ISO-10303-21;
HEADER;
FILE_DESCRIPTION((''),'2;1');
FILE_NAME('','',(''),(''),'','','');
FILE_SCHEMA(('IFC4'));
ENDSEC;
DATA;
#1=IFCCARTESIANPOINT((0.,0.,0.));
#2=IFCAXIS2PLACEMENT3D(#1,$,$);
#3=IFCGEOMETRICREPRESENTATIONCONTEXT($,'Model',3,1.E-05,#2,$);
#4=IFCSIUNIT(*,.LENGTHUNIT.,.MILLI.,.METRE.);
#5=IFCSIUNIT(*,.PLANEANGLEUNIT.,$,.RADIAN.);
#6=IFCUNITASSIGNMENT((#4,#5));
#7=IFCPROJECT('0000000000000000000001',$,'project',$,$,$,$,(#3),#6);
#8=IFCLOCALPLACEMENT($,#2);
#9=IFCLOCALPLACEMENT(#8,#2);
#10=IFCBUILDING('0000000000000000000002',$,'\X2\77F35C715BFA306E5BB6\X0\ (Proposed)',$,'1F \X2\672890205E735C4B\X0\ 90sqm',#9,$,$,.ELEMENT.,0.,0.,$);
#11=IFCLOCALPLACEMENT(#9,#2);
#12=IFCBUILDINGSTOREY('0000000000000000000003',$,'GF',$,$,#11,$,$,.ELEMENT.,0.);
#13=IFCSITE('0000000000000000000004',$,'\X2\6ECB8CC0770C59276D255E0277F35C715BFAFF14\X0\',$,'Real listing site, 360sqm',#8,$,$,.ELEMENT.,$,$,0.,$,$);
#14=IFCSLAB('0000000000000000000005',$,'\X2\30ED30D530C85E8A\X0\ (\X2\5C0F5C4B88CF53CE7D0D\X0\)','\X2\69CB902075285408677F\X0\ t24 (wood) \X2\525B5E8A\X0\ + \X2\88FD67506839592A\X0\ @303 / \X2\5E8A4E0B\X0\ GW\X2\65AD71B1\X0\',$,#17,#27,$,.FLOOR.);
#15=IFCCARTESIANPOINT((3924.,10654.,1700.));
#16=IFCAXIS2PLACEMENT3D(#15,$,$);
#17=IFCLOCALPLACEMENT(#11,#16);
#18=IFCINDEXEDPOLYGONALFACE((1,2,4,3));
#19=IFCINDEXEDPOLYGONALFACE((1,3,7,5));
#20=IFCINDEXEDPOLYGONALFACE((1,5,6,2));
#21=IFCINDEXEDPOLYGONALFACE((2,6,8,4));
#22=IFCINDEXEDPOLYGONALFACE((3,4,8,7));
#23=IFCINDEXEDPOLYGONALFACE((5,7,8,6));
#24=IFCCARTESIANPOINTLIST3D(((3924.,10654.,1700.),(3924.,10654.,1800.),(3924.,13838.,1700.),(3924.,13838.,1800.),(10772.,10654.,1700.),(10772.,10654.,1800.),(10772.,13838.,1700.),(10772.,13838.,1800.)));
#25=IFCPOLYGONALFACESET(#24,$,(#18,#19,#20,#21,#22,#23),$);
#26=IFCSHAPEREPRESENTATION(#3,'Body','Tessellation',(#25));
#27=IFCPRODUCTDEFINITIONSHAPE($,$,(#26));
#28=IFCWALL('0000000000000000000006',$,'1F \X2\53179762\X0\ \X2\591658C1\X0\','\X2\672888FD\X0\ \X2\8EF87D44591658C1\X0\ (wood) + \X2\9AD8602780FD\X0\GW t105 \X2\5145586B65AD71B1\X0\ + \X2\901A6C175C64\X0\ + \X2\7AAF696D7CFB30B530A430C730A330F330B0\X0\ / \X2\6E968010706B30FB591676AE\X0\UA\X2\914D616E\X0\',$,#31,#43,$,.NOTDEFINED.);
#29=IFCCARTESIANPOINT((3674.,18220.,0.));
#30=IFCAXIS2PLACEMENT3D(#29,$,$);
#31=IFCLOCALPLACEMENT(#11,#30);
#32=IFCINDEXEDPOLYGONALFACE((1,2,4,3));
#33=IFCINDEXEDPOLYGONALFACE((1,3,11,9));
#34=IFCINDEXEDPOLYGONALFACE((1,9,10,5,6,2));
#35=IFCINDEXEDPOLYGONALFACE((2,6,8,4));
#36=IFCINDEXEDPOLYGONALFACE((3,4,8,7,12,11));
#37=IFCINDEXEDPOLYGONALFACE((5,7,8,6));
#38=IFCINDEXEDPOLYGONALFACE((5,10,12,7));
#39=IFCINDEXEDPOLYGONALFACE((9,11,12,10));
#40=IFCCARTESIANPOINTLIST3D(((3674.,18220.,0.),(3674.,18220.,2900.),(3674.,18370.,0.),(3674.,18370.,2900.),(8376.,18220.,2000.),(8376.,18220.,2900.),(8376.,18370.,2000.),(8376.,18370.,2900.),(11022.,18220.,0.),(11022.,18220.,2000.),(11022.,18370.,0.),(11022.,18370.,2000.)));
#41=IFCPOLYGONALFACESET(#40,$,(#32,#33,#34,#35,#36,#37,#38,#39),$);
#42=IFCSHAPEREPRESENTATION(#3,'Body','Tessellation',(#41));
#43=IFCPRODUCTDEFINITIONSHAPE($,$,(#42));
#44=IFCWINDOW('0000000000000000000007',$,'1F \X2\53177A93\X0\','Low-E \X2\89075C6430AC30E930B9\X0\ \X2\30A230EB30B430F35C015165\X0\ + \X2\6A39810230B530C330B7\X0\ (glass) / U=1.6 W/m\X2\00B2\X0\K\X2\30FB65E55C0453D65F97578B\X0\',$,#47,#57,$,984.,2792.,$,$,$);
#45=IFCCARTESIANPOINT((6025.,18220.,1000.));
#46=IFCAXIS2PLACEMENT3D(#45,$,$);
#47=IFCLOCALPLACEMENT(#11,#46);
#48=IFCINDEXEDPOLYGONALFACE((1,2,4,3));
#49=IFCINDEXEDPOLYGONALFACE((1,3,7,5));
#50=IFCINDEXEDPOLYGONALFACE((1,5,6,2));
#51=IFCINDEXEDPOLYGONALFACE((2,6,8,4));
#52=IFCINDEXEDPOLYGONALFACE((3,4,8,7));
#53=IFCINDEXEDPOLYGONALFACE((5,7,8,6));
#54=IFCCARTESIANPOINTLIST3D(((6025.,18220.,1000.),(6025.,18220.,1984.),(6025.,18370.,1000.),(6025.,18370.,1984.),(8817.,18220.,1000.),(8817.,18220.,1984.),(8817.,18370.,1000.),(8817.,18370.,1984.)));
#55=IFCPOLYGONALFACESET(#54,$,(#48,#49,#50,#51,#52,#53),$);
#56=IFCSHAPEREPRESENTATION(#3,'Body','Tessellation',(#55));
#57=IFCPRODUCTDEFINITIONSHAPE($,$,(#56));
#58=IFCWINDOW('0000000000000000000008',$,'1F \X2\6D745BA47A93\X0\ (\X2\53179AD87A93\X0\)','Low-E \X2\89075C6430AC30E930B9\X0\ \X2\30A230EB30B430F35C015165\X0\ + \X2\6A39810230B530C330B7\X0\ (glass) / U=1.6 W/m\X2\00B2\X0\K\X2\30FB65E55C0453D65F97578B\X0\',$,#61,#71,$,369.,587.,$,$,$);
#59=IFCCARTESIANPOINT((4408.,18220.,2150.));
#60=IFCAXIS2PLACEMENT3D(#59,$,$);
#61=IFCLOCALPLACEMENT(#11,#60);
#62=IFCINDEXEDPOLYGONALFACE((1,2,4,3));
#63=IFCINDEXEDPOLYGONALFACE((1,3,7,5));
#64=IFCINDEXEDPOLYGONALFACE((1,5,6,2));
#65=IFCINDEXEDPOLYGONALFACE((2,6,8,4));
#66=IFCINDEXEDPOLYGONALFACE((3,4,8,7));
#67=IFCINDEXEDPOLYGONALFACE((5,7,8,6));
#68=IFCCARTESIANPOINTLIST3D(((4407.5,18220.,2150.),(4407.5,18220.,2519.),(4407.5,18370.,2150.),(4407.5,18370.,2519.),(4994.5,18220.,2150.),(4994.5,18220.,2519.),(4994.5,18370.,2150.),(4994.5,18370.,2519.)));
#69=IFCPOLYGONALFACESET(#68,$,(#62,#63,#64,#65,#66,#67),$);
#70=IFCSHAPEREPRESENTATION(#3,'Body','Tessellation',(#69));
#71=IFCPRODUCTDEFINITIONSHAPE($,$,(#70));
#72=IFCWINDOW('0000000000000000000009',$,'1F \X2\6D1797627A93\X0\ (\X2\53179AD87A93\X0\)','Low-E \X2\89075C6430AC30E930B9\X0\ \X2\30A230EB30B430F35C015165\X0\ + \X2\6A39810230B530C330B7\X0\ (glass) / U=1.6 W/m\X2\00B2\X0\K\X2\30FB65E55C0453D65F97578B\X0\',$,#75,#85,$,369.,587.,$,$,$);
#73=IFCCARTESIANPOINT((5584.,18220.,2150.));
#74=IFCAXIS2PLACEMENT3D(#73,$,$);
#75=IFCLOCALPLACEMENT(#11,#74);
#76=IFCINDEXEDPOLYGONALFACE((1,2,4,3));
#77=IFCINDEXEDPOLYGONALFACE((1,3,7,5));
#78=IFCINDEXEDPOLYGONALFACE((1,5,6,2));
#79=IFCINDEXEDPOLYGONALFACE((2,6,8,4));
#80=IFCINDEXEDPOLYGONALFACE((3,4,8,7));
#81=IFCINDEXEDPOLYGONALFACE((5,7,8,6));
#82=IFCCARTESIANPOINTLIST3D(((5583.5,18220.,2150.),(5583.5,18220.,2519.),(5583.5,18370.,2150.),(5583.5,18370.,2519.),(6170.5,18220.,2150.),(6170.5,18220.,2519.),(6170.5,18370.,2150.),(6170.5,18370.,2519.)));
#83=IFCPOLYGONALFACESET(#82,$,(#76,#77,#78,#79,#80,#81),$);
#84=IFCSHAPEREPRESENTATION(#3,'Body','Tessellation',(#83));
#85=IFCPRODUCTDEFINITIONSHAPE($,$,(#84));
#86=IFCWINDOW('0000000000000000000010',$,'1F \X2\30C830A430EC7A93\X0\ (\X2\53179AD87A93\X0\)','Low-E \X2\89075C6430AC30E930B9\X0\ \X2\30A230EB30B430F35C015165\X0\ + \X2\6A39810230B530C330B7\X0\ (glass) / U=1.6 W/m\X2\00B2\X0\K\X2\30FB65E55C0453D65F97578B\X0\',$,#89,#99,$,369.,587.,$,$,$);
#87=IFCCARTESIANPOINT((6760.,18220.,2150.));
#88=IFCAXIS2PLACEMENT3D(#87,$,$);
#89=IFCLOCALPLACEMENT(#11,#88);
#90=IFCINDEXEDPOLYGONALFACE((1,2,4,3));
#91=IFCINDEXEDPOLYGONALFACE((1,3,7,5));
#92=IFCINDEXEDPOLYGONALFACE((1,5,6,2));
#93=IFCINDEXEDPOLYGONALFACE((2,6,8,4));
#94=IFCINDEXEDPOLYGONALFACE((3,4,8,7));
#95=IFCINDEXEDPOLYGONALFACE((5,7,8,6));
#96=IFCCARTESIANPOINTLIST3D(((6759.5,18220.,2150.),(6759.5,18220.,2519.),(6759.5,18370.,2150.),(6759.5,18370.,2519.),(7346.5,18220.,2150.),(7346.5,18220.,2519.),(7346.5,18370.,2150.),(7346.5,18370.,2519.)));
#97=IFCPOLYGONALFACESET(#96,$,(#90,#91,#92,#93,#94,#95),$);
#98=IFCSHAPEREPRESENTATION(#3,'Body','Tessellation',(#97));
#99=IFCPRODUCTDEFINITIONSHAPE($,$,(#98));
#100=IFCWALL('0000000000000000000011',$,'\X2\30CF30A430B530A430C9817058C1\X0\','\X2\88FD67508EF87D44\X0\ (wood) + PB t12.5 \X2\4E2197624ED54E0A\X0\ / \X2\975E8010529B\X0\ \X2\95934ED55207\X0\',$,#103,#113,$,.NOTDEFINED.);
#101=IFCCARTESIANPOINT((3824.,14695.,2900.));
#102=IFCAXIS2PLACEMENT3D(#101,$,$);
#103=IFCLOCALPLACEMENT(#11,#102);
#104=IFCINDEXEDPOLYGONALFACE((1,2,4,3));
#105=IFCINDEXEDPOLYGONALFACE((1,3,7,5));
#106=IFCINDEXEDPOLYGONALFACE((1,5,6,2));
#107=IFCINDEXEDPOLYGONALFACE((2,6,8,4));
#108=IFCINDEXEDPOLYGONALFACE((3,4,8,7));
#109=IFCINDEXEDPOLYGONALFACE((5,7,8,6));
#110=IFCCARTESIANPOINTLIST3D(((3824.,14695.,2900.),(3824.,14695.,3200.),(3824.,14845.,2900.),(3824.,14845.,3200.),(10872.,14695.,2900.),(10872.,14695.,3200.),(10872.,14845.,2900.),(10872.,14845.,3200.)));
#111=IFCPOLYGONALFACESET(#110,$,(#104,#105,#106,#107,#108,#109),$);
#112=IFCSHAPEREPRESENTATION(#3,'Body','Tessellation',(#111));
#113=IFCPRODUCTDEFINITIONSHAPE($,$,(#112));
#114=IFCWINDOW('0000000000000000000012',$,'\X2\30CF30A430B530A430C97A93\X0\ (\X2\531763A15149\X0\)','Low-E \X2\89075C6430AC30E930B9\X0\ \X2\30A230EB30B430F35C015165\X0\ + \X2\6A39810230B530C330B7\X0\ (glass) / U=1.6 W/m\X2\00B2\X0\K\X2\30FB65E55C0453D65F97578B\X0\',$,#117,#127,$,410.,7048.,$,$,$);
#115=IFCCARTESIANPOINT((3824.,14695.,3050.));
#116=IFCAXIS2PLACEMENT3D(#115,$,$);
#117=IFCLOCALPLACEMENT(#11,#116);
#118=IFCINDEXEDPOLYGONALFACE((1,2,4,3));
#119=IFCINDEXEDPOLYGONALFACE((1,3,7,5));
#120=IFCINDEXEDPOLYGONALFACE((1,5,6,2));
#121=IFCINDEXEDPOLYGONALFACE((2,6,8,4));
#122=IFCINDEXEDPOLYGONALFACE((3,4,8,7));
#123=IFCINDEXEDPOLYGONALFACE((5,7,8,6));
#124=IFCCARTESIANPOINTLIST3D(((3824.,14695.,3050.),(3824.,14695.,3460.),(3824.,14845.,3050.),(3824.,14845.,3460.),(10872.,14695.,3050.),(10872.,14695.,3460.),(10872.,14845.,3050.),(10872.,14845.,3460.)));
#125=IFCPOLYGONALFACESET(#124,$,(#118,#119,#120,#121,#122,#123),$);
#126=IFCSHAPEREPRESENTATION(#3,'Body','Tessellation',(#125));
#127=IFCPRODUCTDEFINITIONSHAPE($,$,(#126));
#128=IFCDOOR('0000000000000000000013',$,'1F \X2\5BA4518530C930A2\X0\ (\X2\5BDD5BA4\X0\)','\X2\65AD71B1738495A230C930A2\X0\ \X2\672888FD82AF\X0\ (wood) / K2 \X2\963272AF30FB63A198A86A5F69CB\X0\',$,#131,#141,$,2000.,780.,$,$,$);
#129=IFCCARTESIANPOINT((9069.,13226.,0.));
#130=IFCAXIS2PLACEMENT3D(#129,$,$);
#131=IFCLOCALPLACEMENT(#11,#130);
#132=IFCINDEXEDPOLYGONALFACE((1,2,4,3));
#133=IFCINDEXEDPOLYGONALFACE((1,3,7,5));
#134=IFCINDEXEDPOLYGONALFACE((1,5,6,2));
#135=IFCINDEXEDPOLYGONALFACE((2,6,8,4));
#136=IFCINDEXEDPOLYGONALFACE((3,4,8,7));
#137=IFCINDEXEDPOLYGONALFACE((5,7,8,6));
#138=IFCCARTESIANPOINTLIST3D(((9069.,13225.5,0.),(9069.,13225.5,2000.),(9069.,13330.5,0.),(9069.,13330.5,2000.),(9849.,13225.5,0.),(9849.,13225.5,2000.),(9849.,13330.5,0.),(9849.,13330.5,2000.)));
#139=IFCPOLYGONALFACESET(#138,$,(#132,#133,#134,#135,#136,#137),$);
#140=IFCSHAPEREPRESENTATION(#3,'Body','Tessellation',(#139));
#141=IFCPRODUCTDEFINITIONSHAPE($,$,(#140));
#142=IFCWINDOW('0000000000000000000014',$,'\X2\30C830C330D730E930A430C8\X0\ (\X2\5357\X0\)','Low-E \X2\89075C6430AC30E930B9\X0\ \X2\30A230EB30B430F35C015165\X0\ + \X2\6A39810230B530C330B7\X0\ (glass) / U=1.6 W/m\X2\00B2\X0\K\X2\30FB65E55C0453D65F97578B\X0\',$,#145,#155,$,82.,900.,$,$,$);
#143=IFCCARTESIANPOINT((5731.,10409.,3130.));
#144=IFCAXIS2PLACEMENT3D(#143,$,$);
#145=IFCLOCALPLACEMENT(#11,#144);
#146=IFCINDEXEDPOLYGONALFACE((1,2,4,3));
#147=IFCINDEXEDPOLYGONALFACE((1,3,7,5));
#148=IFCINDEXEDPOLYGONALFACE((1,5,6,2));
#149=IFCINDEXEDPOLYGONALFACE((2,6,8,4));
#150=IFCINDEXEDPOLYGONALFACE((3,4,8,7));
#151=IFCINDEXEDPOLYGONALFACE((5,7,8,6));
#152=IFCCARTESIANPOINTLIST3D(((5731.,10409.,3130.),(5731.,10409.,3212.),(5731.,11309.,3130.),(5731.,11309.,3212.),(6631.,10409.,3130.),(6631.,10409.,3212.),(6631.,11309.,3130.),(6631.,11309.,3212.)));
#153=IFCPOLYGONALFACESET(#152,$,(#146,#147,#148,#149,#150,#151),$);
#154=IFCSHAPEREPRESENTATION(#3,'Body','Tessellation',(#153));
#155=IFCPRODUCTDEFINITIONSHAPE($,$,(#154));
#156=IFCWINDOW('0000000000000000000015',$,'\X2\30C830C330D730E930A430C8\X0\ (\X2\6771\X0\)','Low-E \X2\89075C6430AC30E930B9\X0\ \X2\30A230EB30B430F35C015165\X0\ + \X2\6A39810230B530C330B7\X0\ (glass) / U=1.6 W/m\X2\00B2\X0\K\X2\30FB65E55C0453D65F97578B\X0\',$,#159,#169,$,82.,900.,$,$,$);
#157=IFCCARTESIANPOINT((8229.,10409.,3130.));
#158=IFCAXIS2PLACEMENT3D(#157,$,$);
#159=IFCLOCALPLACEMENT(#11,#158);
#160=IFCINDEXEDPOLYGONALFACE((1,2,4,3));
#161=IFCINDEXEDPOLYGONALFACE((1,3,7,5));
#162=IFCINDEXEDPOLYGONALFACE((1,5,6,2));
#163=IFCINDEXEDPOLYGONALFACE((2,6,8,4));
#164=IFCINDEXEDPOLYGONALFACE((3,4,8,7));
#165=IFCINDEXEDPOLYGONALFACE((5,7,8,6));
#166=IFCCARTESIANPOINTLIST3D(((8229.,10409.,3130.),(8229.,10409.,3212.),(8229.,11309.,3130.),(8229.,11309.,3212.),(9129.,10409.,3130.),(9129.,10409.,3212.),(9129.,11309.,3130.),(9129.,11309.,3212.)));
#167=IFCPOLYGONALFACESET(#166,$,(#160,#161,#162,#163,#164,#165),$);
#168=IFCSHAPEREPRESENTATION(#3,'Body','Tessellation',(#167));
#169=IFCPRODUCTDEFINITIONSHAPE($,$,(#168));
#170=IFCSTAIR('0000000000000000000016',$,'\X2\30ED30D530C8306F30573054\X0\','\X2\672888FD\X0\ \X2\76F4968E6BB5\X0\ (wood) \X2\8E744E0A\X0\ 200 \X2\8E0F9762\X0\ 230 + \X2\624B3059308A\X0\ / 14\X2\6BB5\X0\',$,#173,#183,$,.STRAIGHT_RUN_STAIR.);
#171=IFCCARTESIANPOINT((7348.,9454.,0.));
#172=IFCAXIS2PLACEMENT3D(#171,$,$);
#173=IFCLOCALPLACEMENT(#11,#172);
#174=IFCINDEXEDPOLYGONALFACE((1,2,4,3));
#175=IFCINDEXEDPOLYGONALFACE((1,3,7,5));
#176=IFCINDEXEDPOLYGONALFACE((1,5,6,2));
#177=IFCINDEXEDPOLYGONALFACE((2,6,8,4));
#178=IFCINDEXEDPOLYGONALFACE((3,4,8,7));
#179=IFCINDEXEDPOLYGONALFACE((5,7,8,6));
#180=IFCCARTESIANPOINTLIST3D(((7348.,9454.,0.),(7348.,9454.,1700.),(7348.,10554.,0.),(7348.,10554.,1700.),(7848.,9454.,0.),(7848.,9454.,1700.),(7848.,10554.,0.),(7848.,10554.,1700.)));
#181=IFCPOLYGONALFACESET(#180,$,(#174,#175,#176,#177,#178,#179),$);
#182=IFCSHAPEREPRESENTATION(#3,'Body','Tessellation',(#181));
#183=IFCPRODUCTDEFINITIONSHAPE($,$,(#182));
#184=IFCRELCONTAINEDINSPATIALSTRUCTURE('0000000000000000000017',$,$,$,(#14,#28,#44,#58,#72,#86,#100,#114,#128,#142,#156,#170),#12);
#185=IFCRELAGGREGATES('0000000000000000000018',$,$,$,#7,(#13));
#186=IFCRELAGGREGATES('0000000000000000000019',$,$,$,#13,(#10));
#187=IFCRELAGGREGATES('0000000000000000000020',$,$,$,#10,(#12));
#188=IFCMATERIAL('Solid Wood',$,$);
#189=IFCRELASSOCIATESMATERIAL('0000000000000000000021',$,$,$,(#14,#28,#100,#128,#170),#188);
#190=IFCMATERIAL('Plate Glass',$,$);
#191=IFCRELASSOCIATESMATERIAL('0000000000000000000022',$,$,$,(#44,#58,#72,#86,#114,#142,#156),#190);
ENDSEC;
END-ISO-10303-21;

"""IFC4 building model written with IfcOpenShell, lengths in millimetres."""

from ifc_helpers import new_model, si_unit, frame, frame_2d, origin, place, context, project, spatial, rectangle, extrude, material, element, fill, save


model = new_model("IFC4")

# Units and contexts
model_context = context("Model", 3, precision=1e-05, world=origin())
ifc_project = project(units=[si_unit("LENGTHUNIT", "METRE", prefix="MILLI"), si_unit("PLANEANGLEUNIT", "RADIAN")], contexts=[model_context])

# Site, building, storey
site_placement = place(None, origin())
site = spatial("IfcSite", under=ifc_project, at=site_placement, Name="滋賀県大津市石山寺４", ObjectType="Real listing site, 360sqm", CompositionType="ELEMENT", RefElevation=0.0)
building_placement = place(site_placement, origin())
building = spatial("IfcBuilding", under=site, at=building_placement, Name="石山寺の家 (Proposed)", ObjectType="1F 木造平屋 90sqm", CompositionType="ELEMENT", ElevationOfRefHeight=0.0, ElevationOfTerrain=0.0)
storey_placement = place(building_placement, origin())
storey = spatial("IfcBuildingStorey", under=building, at=storey_placement, Name="GF", CompositionType="ELEMENT", Elevation=0.0)

# Slab
ifc_material_1 = material(Name="Solid Wood")
slab_placement = place(storey_placement, frame((3924.0, 10654.0, 1700.0)))
element("IfcSlab", 1, at=slab_placement, inside=storey, material=ifc_material_1, Name="ロフト床 (小屋裏収納)", Description="構造用合板 t24 (wood) 剛床 + 製材根太 @303 / 床下 GW断熱", PredefinedType="FLOOR", context=model_context, shape_type="SweptSolid", body=[
    extrude(rectangle(XDim=6848.0, YDim=3184.0, at=frame_2d((3424.0, 1592.0))), frame((3924.0, 10654.0, 1700.0)), (0.0, 0.0, 1.0), 100.0),
])

# Wall, openings, windows
wall_1_placement = place(storey_placement, frame((3674.0, 18220.0, 0.0)))
wall_1 = element("IfcWall", 2, at=wall_1_placement, inside=storey, material=ifc_material_1, Name="1F 北面 外壁", Description="木製 軸組外壁 (wood) + 高性能GW t105 充填断熱 + 通気層 + 窯業系サイディング / 準耐火・外皮UA配慮", PredefinedType="NOTDEFINED", context=model_context, shape_type="SweptSolid", body=[
    extrude(rectangle(XDim=7348.0, YDim=150.0, at=frame_2d((3674.0, 75.0))), frame((3674.0, 18220.0, 0.0)), (0.0, 0.0, 1.0), 2900.0),
])
opening_1_placement = place(storey_placement, frame((6025.0, 18220.0, 1000.0)))
opening_1 = element("IfcOpeningElement", 3, at=opening_1_placement, cuts=wall_1, PredefinedType="NOTDEFINED", context=model_context, shape_type="SweptSolid", body=[
    extrude(rectangle(XDim=2792.0, YDim=150.0, at=frame_2d((1396.0, 75.0))), frame((6025.0, 18220.0, 1000.0)), (0.0, 0.0, 1.0), 984.0),
])
opening_2_placement = place(storey_placement, frame((4408.0, 18220.0, 2150.0)))
opening_2 = element("IfcOpeningElement", 4, at=opening_2_placement, cuts=wall_1, PredefinedType="NOTDEFINED", context=model_context, shape_type="SweptSolid", body=[
    extrude(rectangle(XDim=587.0, YDim=150.0, at=frame_2d((293.0, 75.0))), frame((4408.0, 18220.0, 2150.0)), (0.0, 0.0, 1.0), 369.0),
])
opening_3_placement = place(storey_placement, frame((5584.0, 18220.0, 2150.0)))
opening_3 = element("IfcOpeningElement", 5, at=opening_3_placement, cuts=wall_1, PredefinedType="NOTDEFINED", context=model_context, shape_type="SweptSolid", body=[
    extrude(rectangle(XDim=587.0, YDim=150.0, at=frame_2d((293.0, 75.0))), frame((5584.0, 18220.0, 2150.0)), (0.0, 0.0, 1.0), 369.0),
])
opening_4_placement = place(storey_placement, frame((6760.0, 18220.0, 2150.0)))
opening_4 = element("IfcOpeningElement", 6, at=opening_4_placement, cuts=wall_1, PredefinedType="NOTDEFINED", context=model_context, shape_type="SweptSolid", body=[
    extrude(rectangle(XDim=587.0, YDim=150.0, at=frame_2d((293.0, 75.0))), frame((6760.0, 18220.0, 2150.0)), (0.0, 0.0, 1.0), 369.0),
])
ifc_material_2 = material(Name="Plate Glass")
window_1_placement = place(storey_placement, frame((6025.0, 18220.0, 1000.0)))
window_1 = element("IfcWindow", 7, at=window_1_placement, inside=storey, material=ifc_material_2, Name="1F 北窓", Description="Low-E 複層ガラス アルゴン封入 + 樹脂サッシ (glass) / U=1.6 W/m²K・日射取得型", OverallHeight=984.0, OverallWidth=2792.0, context=model_context, shape_type="SweptSolid", body=[
    extrude(rectangle(XDim=2792.0, YDim=150.0, at=frame_2d((1396.0, 75.0))), frame((6025.0, 18220.0, 1000.0)), (0.0, 0.0, 1.0), 984.0),
])
fill(opening_1, window_1)
window_2_placement = place(storey_placement, frame((4408.0, 18220.0, 2150.0)))
window_2 = element("IfcWindow", 8, at=window_2_placement, inside=storey, material=ifc_material_2, Name="1F 浴室窓 (北高窓)", Description="Low-E 複層ガラス アルゴン封入 + 樹脂サッシ (glass) / U=1.6 W/m²K・日射取得型", OverallHeight=369.0, OverallWidth=587.0, context=model_context, shape_type="SweptSolid", body=[
    extrude(rectangle(XDim=587.0, YDim=150.0, at=frame_2d((293.0, 75.0))), frame((4408.0, 18220.0, 2150.0)), (0.0, 0.0, 1.0), 369.0),
])
fill(opening_2, window_2)
window_3_placement = place(storey_placement, frame((5584.0, 18220.0, 2150.0)))
window_3 = element("IfcWindow", 9, at=window_3_placement, inside=storey, material=ifc_material_2, Name="1F 洗面窓 (北高窓)", Description="Low-E 複層ガラス アルゴン封入 + 樹脂サッシ (glass) / U=1.6 W/m²K・日射取得型", OverallHeight=369.0, OverallWidth=587.0, context=model_context, shape_type="SweptSolid", body=[
    extrude(rectangle(XDim=587.0, YDim=150.0, at=frame_2d((293.0, 75.0))), frame((5584.0, 18220.0, 2150.0)), (0.0, 0.0, 1.0), 369.0),
])
fill(opening_3, window_3)
window_4_placement = place(storey_placement, frame((6760.0, 18220.0, 2150.0)))
window_4 = element("IfcWindow", 10, at=window_4_placement, inside=storey, material=ifc_material_2, Name="1F トイレ窓 (北高窓)", Description="Low-E 複層ガラス アルゴン封入 + 樹脂サッシ (glass) / U=1.6 W/m²K・日射取得型", OverallHeight=369.0, OverallWidth=587.0, context=model_context, shape_type="SweptSolid", body=[
    extrude(rectangle(XDim=587.0, YDim=150.0, at=frame_2d((293.0, 75.0))), frame((6760.0, 18220.0, 2150.0)), (0.0, 0.0, 1.0), 369.0),
])
fill(opening_4, window_4)

# Wall, opening, window
wall_2_placement = place(storey_placement, frame((3824.0, 14695.0, 2900.0)))
wall_2 = element("IfcWall", 11, at=wall_2_placement, inside=storey, material=ifc_material_1, Name="ハイサイド腰壁", Description="製材軸組 (wood) + PB t12.5 両面仕上 / 非耐力 間仕切", PredefinedType="NOTDEFINED", context=model_context, shape_type="SweptSolid", body=[
    extrude(rectangle(XDim=7048.0, YDim=150.0, at=frame_2d((3524.0, 75.0))), frame((3824.0, 14695.0, 2900.0)), (0.0, 0.0, 1.0), 700.0),
])
opening_5_placement = place(storey_placement, frame((3824.0, 14695.0, 3050.0)))
opening_5 = element("IfcOpeningElement", 12, at=opening_5_placement, cuts=wall_2, PredefinedType="NOTDEFINED", context=model_context, shape_type="SweptSolid", body=[
    extrude(rectangle(XDim=7048.0, YDim=150.0, at=frame_2d((3524.0, 75.0))), frame((3824.0, 14695.0, 3050.0)), (0.0, 0.0, 1.0), 410.0),
])
window_5_placement = place(storey_placement, frame((3824.0, 14695.0, 3050.0)))
window_5 = element("IfcWindow", 13, at=window_5_placement, inside=storey, material=ifc_material_2, Name="ハイサイド窓 (北採光)", Description="Low-E 複層ガラス アルゴン封入 + 樹脂サッシ (glass) / U=1.6 W/m²K・日射取得型", OverallHeight=410.0, OverallWidth=7048.0, context=model_context, shape_type="SweptSolid", body=[
    extrude(rectangle(XDim=7048.0, YDim=150.0, at=frame_2d((3524.0, 75.0))), frame((3824.0, 14695.0, 3050.0)), (0.0, 0.0, 1.0), 410.0),
])
fill(opening_5, window_5)

# Door
door_1_placement = place(storey_placement, frame((9069.0, 13226.0, 0.0)))
element("IfcDoor", 14, at=door_1_placement, inside=storey, material=ifc_material_1, Name="1F 室内ドア (寝室)", Description="断熱玄関ドア 木製芯 (wood) / K2 防犯・採風機構", OverallHeight=2000.0, OverallWidth=780.0, context=model_context, shape_type="SweptSolid", body=[
    extrude(rectangle(XDim=780.0, YDim=105.0, at=frame_2d((390.0, 52.0))), frame((9069.0, 13226.0, 0.0)), (0.0, 0.0, 1.0), 2000.0),
])

# Windows
window_6_placement = place(storey_placement, frame((5731.0, 10409.0, 3130.0)))
element("IfcWindow", 15, at=window_6_placement, inside=storey, material=ifc_material_2, Name="トップライト (南)", Description="Low-E 複層ガラス アルゴン封入 + 樹脂サッシ (glass) / U=1.6 W/m²K・日射取得型", OverallHeight=82.0, OverallWidth=900.0, context=model_context, shape_type="SweptSolid", body=[
    extrude(rectangle(XDim=900.0, YDim=900.0, at=frame_2d((450.0, 450.0))), frame((5731.0, 10409.0, 3130.0)), (0.0, 0.0, 1.0), 82.0),
])
window_7_placement = place(storey_placement, frame((8229.0, 10409.0, 3130.0)))
element("IfcWindow", 16, at=window_7_placement, inside=storey, material=ifc_material_2, Name="トップライト (東)", Description="Low-E 複層ガラス アルゴン封入 + 樹脂サッシ (glass) / U=1.6 W/m²K・日射取得型", OverallHeight=82.0, OverallWidth=900.0, context=model_context, shape_type="SweptSolid", body=[
    extrude(rectangle(XDim=900.0, YDim=900.0, at=frame_2d((450.0, 450.0))), frame((8229.0, 10409.0, 3130.0)), (0.0, 0.0, 1.0), 82.0),
])

# Stair
stair_placement = place(storey_placement, frame((7348.0, 9454.0, 0.0)))
element("IfcStair", 17, at=stair_placement, inside=storey, material=ifc_material_1, Name="ロフトはしご", Description="木製 直階段 (wood) 蹴上 200 踏面 230 + 手すり / 14段", PredefinedType="STRAIGHT_RUN_STAIR", context=model_context, shape_type="SweptSolid", body=[
    extrude(rectangle(XDim=500.0, YDim=1100.0, at=frame_2d((250.0, 550.0))), frame((7348.0, 9454.0, 0.0)), (0.0, 0.0, 1.0), 1700.0),
])

save(model, "model.ifc")
